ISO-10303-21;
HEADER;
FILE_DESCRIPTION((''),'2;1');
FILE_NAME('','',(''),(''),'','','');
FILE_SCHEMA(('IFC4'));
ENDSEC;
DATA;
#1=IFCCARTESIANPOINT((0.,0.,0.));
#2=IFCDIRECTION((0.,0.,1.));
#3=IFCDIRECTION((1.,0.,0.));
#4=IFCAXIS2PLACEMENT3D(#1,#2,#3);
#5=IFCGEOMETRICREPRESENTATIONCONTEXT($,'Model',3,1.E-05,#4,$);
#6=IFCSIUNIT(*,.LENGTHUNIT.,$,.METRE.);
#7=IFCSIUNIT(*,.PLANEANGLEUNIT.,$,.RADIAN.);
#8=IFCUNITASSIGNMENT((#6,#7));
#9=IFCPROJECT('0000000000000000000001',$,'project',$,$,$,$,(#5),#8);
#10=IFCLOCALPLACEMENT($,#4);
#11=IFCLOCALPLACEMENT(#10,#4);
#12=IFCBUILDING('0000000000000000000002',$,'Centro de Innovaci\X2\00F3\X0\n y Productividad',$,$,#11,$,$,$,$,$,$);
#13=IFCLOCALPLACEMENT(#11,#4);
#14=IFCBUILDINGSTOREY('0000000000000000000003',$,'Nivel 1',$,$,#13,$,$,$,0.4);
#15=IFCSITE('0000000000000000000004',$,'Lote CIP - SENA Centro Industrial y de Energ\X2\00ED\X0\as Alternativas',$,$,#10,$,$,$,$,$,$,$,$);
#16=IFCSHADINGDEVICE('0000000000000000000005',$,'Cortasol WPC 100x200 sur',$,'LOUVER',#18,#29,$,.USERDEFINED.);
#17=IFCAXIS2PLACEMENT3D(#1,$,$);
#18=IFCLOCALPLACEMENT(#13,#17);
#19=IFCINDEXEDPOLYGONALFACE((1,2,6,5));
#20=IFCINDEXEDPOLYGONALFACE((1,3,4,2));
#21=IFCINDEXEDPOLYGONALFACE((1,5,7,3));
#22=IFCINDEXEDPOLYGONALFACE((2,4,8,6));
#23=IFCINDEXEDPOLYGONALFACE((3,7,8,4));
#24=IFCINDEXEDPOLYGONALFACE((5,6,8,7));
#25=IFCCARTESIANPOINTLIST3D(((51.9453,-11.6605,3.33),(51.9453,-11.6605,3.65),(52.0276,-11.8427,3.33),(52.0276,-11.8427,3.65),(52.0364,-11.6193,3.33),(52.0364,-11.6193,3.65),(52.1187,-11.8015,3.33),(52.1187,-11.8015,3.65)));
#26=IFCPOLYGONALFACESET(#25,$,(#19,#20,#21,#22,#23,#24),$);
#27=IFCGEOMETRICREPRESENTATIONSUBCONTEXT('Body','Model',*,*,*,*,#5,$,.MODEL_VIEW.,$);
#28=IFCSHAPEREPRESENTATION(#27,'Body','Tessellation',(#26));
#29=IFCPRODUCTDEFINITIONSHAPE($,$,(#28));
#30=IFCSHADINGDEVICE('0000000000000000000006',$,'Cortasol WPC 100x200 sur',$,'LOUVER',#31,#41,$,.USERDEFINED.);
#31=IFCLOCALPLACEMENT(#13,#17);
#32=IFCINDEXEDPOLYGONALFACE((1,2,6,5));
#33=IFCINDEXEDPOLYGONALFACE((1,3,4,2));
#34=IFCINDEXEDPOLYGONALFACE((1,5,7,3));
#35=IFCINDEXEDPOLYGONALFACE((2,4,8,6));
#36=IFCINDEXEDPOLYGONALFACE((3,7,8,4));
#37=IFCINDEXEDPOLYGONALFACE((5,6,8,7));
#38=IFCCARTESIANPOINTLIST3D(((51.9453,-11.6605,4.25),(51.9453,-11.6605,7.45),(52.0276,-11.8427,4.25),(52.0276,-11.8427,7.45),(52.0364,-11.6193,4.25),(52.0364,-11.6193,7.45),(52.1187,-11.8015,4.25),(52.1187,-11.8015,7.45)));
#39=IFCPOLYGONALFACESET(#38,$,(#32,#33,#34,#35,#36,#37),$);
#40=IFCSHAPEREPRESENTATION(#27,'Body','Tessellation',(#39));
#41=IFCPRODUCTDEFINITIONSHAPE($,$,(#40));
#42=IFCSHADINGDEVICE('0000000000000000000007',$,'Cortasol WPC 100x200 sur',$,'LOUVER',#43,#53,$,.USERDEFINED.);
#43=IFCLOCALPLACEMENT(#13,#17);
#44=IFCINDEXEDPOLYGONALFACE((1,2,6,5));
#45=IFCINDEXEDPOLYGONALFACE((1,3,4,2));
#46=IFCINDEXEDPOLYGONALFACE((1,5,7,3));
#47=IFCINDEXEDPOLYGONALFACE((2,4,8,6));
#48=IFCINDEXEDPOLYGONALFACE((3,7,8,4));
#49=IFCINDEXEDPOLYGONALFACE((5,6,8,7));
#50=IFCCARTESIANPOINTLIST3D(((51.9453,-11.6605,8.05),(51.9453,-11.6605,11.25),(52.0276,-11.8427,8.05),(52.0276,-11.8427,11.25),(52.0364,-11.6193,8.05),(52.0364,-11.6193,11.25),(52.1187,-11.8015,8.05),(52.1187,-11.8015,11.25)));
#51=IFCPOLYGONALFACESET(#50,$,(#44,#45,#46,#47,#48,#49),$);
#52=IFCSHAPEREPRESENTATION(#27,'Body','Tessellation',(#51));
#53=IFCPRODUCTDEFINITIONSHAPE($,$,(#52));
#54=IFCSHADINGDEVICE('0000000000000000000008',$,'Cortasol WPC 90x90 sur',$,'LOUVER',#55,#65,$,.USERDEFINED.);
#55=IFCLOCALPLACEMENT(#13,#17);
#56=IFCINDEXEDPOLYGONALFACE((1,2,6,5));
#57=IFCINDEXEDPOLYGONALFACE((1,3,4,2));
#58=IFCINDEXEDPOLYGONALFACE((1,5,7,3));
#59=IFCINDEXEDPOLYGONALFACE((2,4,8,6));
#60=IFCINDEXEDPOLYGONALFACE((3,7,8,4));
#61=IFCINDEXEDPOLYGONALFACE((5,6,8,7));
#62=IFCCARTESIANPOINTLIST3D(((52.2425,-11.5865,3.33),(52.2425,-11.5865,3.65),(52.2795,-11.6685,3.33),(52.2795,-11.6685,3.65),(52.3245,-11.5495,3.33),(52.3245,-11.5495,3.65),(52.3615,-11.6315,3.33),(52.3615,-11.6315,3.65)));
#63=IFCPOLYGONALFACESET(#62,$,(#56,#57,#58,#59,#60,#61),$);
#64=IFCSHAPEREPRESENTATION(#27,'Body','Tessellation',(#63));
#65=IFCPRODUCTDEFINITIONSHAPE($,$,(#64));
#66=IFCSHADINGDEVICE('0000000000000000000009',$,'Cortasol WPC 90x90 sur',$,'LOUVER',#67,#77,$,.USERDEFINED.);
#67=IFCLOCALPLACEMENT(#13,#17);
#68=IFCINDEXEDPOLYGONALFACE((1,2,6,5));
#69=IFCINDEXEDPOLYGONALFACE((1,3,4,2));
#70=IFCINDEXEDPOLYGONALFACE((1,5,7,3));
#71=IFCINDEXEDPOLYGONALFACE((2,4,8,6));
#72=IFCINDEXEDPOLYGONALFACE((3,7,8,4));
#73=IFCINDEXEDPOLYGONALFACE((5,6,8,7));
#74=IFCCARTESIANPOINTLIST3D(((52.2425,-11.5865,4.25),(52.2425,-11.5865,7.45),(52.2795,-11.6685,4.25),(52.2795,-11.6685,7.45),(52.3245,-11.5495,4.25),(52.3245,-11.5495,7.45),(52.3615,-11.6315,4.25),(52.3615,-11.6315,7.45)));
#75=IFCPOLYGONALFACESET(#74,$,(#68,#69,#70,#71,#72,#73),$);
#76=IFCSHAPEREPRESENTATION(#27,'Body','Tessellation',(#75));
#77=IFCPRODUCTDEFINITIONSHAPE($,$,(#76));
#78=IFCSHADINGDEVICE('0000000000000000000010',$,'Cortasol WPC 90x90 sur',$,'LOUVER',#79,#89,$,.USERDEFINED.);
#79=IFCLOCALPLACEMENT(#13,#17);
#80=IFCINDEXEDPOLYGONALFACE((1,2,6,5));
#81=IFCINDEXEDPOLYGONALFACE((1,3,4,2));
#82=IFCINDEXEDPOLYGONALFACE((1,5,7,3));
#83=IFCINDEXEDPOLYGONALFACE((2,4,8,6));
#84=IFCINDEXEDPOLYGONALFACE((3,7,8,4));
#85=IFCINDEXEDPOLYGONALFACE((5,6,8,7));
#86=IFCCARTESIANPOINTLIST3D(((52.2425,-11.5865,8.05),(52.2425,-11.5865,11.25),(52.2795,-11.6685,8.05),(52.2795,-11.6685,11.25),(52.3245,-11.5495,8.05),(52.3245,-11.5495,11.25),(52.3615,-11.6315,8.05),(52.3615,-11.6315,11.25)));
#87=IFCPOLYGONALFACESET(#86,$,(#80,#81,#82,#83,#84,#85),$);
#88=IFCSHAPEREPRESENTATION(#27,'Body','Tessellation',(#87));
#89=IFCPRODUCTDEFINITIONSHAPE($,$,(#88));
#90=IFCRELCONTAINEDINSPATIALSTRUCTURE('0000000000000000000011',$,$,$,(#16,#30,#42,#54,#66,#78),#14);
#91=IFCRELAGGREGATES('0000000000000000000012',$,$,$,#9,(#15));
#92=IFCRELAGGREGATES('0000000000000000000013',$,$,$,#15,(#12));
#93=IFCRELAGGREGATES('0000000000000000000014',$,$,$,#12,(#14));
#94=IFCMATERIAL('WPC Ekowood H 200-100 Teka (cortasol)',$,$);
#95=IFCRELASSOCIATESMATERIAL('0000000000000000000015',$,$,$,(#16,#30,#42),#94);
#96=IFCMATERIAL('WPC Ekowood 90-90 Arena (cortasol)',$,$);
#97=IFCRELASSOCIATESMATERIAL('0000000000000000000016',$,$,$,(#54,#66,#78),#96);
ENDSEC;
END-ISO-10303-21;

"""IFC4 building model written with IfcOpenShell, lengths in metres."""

from ifc_helpers import new_model, si_unit, frame, origin_with_axes, place, context, subcontext, project, spatial, polyline, outline, extrude, material, element, save


model = new_model("IFC4")

# Units and contexts
model_context = context("Model", 3, precision=1e-05, world=origin_with_axes())
body_context = subcontext(model_context, "Body", "Model", "MODEL_VIEW")
ifc_project = project(units=[si_unit("LENGTHUNIT", "METRE"), si_unit("PLANEANGLEUNIT", "RADIAN")], contexts=[model_context])

# Site, building, storey
site_placement = place(None, origin_with_axes())
site = spatial("IfcSite", under=ifc_project, at=site_placement, Name="Lote CIP - SENA Centro Industrial y de Energías Alternativas")
building_placement = place(site_placement, origin_with_axes())
building = spatial("IfcBuilding", under=site, at=building_placement, Name="Centro de Innovación y Productividad")
storey_placement = place(building_placement, origin_with_axes())
storey = spatial("IfcBuildingStorey", under=building, at=storey_placement, Name="Nivel 1", Elevation=0.4)

# Shading devices
ifc_material_1 = material(Name="WPC Ekowood 90-90 Arena (cortasol)")
ifc_material_2 = material(Name="WPC Ekowood H 200-100 Teka (cortasol)")
shading_device_1_placement = place(storey_placement, origin_with_axes())
element("IfcShadingDevice", 1, at=shading_device_1_placement, inside=storey, material=ifc_material_2, Name="Cortasol WPC 100x200 sur", ObjectType="LOUVER", PredefinedType="USERDEFINED", context=body_context, shape_type="SweptSolid", body=[
    extrude(outline(polyline([(52.0276, -11.8427), (51.9453, -11.6605), (52.0364, -11.6193), (52.1187, -11.8015), (52.0276, -11.8427)])), frame((0.0, 0.0, 3.33)), (0.0, 0.0, 1.0), 0.32),
])
shading_device_2_placement = place(storey_placement, origin_with_axes())
element("IfcShadingDevice", 2, at=shading_device_2_placement, inside=storey, material=ifc_material_2, Name="Cortasol WPC 100x200 sur", ObjectType="LOUVER", PredefinedType="USERDEFINED", context=body_context, shape_type="SweptSolid", body=[
    extrude(outline(polyline([(52.0276, -11.8427), (51.9453, -11.6605), (52.0364, -11.6193), (52.1187, -11.8015), (52.0276, -11.8427)])), frame((0.0, 0.0, 4.25)), (0.0, 0.0, 1.0), 3.2),
])
shading_device_3_placement = place(storey_placement, origin_with_axes())
element("IfcShadingDevice", 3, at=shading_device_3_placement, inside=storey, material=ifc_material_2, Name="Cortasol WPC 100x200 sur", ObjectType="LOUVER", PredefinedType="USERDEFINED", context=body_context, shape_type="SweptSolid", body=[
    extrude(outline(polyline([(52.0276, -11.8427), (51.9453, -11.6605), (52.0364, -11.6193), (52.1187, -11.8015), (52.0276, -11.8427)])), frame((0.0, 0.0, 8.05)), (0.0, 0.0, 1.0), 3.2),
])
shading_device_4_placement = place(storey_placement, origin_with_axes())
element("IfcShadingDevice", 4, at=shading_device_4_placement, inside=storey, material=ifc_material_1, Name="Cortasol WPC 90x90 sur", ObjectType="LOUVER", PredefinedType="USERDEFINED", context=body_context, shape_type="SweptSolid", body=[
    extrude(outline(polyline([(52.2795, -11.6685), (52.2425, -11.5865), (52.3245, -11.5495), (52.3615, -11.6315), (52.2795, -11.6685)])), frame((0.0, 0.0, 3.33)), (0.0, 0.0, 1.0), 0.32),
])
shading_device_5_placement = place(storey_placement, origin_with_axes())
element("IfcShadingDevice", 5, at=shading_device_5_placement, inside=storey, material=ifc_material_1, Name="Cortasol WPC 90x90 sur", ObjectType="LOUVER", PredefinedType="USERDEFINED", context=body_context, shape_type="SweptSolid", body=[
    extrude(outline(polyline([(52.2795, -11.6685), (52.2425, -11.5865), (52.3245, -11.5495), (52.3615, -11.6315), (52.2795, -11.6685)])), frame((0.0, 0.0, 4.25)), (0.0, 0.0, 1.0), 3.2),
])
shading_device_6_placement = place(storey_placement, origin_with_axes())
element("IfcShadingDevice", 6, at=shading_device_6_placement, inside=storey, material=ifc_material_1, Name="Cortasol WPC 90x90 sur", ObjectType="LOUVER", PredefinedType="USERDEFINED", context=body_context, shape_type="SweptSolid", body=[
    extrude(outline(polyline([(52.2795, -11.6685), (52.2425, -11.5865), (52.3245, -11.5495), (52.3615, -11.6315), (52.2795, -11.6685)])), frame((0.0, 0.0, 8.05)), (0.0, 0.0, 1.0), 3.2),
])

save(model, "model.ifc")
